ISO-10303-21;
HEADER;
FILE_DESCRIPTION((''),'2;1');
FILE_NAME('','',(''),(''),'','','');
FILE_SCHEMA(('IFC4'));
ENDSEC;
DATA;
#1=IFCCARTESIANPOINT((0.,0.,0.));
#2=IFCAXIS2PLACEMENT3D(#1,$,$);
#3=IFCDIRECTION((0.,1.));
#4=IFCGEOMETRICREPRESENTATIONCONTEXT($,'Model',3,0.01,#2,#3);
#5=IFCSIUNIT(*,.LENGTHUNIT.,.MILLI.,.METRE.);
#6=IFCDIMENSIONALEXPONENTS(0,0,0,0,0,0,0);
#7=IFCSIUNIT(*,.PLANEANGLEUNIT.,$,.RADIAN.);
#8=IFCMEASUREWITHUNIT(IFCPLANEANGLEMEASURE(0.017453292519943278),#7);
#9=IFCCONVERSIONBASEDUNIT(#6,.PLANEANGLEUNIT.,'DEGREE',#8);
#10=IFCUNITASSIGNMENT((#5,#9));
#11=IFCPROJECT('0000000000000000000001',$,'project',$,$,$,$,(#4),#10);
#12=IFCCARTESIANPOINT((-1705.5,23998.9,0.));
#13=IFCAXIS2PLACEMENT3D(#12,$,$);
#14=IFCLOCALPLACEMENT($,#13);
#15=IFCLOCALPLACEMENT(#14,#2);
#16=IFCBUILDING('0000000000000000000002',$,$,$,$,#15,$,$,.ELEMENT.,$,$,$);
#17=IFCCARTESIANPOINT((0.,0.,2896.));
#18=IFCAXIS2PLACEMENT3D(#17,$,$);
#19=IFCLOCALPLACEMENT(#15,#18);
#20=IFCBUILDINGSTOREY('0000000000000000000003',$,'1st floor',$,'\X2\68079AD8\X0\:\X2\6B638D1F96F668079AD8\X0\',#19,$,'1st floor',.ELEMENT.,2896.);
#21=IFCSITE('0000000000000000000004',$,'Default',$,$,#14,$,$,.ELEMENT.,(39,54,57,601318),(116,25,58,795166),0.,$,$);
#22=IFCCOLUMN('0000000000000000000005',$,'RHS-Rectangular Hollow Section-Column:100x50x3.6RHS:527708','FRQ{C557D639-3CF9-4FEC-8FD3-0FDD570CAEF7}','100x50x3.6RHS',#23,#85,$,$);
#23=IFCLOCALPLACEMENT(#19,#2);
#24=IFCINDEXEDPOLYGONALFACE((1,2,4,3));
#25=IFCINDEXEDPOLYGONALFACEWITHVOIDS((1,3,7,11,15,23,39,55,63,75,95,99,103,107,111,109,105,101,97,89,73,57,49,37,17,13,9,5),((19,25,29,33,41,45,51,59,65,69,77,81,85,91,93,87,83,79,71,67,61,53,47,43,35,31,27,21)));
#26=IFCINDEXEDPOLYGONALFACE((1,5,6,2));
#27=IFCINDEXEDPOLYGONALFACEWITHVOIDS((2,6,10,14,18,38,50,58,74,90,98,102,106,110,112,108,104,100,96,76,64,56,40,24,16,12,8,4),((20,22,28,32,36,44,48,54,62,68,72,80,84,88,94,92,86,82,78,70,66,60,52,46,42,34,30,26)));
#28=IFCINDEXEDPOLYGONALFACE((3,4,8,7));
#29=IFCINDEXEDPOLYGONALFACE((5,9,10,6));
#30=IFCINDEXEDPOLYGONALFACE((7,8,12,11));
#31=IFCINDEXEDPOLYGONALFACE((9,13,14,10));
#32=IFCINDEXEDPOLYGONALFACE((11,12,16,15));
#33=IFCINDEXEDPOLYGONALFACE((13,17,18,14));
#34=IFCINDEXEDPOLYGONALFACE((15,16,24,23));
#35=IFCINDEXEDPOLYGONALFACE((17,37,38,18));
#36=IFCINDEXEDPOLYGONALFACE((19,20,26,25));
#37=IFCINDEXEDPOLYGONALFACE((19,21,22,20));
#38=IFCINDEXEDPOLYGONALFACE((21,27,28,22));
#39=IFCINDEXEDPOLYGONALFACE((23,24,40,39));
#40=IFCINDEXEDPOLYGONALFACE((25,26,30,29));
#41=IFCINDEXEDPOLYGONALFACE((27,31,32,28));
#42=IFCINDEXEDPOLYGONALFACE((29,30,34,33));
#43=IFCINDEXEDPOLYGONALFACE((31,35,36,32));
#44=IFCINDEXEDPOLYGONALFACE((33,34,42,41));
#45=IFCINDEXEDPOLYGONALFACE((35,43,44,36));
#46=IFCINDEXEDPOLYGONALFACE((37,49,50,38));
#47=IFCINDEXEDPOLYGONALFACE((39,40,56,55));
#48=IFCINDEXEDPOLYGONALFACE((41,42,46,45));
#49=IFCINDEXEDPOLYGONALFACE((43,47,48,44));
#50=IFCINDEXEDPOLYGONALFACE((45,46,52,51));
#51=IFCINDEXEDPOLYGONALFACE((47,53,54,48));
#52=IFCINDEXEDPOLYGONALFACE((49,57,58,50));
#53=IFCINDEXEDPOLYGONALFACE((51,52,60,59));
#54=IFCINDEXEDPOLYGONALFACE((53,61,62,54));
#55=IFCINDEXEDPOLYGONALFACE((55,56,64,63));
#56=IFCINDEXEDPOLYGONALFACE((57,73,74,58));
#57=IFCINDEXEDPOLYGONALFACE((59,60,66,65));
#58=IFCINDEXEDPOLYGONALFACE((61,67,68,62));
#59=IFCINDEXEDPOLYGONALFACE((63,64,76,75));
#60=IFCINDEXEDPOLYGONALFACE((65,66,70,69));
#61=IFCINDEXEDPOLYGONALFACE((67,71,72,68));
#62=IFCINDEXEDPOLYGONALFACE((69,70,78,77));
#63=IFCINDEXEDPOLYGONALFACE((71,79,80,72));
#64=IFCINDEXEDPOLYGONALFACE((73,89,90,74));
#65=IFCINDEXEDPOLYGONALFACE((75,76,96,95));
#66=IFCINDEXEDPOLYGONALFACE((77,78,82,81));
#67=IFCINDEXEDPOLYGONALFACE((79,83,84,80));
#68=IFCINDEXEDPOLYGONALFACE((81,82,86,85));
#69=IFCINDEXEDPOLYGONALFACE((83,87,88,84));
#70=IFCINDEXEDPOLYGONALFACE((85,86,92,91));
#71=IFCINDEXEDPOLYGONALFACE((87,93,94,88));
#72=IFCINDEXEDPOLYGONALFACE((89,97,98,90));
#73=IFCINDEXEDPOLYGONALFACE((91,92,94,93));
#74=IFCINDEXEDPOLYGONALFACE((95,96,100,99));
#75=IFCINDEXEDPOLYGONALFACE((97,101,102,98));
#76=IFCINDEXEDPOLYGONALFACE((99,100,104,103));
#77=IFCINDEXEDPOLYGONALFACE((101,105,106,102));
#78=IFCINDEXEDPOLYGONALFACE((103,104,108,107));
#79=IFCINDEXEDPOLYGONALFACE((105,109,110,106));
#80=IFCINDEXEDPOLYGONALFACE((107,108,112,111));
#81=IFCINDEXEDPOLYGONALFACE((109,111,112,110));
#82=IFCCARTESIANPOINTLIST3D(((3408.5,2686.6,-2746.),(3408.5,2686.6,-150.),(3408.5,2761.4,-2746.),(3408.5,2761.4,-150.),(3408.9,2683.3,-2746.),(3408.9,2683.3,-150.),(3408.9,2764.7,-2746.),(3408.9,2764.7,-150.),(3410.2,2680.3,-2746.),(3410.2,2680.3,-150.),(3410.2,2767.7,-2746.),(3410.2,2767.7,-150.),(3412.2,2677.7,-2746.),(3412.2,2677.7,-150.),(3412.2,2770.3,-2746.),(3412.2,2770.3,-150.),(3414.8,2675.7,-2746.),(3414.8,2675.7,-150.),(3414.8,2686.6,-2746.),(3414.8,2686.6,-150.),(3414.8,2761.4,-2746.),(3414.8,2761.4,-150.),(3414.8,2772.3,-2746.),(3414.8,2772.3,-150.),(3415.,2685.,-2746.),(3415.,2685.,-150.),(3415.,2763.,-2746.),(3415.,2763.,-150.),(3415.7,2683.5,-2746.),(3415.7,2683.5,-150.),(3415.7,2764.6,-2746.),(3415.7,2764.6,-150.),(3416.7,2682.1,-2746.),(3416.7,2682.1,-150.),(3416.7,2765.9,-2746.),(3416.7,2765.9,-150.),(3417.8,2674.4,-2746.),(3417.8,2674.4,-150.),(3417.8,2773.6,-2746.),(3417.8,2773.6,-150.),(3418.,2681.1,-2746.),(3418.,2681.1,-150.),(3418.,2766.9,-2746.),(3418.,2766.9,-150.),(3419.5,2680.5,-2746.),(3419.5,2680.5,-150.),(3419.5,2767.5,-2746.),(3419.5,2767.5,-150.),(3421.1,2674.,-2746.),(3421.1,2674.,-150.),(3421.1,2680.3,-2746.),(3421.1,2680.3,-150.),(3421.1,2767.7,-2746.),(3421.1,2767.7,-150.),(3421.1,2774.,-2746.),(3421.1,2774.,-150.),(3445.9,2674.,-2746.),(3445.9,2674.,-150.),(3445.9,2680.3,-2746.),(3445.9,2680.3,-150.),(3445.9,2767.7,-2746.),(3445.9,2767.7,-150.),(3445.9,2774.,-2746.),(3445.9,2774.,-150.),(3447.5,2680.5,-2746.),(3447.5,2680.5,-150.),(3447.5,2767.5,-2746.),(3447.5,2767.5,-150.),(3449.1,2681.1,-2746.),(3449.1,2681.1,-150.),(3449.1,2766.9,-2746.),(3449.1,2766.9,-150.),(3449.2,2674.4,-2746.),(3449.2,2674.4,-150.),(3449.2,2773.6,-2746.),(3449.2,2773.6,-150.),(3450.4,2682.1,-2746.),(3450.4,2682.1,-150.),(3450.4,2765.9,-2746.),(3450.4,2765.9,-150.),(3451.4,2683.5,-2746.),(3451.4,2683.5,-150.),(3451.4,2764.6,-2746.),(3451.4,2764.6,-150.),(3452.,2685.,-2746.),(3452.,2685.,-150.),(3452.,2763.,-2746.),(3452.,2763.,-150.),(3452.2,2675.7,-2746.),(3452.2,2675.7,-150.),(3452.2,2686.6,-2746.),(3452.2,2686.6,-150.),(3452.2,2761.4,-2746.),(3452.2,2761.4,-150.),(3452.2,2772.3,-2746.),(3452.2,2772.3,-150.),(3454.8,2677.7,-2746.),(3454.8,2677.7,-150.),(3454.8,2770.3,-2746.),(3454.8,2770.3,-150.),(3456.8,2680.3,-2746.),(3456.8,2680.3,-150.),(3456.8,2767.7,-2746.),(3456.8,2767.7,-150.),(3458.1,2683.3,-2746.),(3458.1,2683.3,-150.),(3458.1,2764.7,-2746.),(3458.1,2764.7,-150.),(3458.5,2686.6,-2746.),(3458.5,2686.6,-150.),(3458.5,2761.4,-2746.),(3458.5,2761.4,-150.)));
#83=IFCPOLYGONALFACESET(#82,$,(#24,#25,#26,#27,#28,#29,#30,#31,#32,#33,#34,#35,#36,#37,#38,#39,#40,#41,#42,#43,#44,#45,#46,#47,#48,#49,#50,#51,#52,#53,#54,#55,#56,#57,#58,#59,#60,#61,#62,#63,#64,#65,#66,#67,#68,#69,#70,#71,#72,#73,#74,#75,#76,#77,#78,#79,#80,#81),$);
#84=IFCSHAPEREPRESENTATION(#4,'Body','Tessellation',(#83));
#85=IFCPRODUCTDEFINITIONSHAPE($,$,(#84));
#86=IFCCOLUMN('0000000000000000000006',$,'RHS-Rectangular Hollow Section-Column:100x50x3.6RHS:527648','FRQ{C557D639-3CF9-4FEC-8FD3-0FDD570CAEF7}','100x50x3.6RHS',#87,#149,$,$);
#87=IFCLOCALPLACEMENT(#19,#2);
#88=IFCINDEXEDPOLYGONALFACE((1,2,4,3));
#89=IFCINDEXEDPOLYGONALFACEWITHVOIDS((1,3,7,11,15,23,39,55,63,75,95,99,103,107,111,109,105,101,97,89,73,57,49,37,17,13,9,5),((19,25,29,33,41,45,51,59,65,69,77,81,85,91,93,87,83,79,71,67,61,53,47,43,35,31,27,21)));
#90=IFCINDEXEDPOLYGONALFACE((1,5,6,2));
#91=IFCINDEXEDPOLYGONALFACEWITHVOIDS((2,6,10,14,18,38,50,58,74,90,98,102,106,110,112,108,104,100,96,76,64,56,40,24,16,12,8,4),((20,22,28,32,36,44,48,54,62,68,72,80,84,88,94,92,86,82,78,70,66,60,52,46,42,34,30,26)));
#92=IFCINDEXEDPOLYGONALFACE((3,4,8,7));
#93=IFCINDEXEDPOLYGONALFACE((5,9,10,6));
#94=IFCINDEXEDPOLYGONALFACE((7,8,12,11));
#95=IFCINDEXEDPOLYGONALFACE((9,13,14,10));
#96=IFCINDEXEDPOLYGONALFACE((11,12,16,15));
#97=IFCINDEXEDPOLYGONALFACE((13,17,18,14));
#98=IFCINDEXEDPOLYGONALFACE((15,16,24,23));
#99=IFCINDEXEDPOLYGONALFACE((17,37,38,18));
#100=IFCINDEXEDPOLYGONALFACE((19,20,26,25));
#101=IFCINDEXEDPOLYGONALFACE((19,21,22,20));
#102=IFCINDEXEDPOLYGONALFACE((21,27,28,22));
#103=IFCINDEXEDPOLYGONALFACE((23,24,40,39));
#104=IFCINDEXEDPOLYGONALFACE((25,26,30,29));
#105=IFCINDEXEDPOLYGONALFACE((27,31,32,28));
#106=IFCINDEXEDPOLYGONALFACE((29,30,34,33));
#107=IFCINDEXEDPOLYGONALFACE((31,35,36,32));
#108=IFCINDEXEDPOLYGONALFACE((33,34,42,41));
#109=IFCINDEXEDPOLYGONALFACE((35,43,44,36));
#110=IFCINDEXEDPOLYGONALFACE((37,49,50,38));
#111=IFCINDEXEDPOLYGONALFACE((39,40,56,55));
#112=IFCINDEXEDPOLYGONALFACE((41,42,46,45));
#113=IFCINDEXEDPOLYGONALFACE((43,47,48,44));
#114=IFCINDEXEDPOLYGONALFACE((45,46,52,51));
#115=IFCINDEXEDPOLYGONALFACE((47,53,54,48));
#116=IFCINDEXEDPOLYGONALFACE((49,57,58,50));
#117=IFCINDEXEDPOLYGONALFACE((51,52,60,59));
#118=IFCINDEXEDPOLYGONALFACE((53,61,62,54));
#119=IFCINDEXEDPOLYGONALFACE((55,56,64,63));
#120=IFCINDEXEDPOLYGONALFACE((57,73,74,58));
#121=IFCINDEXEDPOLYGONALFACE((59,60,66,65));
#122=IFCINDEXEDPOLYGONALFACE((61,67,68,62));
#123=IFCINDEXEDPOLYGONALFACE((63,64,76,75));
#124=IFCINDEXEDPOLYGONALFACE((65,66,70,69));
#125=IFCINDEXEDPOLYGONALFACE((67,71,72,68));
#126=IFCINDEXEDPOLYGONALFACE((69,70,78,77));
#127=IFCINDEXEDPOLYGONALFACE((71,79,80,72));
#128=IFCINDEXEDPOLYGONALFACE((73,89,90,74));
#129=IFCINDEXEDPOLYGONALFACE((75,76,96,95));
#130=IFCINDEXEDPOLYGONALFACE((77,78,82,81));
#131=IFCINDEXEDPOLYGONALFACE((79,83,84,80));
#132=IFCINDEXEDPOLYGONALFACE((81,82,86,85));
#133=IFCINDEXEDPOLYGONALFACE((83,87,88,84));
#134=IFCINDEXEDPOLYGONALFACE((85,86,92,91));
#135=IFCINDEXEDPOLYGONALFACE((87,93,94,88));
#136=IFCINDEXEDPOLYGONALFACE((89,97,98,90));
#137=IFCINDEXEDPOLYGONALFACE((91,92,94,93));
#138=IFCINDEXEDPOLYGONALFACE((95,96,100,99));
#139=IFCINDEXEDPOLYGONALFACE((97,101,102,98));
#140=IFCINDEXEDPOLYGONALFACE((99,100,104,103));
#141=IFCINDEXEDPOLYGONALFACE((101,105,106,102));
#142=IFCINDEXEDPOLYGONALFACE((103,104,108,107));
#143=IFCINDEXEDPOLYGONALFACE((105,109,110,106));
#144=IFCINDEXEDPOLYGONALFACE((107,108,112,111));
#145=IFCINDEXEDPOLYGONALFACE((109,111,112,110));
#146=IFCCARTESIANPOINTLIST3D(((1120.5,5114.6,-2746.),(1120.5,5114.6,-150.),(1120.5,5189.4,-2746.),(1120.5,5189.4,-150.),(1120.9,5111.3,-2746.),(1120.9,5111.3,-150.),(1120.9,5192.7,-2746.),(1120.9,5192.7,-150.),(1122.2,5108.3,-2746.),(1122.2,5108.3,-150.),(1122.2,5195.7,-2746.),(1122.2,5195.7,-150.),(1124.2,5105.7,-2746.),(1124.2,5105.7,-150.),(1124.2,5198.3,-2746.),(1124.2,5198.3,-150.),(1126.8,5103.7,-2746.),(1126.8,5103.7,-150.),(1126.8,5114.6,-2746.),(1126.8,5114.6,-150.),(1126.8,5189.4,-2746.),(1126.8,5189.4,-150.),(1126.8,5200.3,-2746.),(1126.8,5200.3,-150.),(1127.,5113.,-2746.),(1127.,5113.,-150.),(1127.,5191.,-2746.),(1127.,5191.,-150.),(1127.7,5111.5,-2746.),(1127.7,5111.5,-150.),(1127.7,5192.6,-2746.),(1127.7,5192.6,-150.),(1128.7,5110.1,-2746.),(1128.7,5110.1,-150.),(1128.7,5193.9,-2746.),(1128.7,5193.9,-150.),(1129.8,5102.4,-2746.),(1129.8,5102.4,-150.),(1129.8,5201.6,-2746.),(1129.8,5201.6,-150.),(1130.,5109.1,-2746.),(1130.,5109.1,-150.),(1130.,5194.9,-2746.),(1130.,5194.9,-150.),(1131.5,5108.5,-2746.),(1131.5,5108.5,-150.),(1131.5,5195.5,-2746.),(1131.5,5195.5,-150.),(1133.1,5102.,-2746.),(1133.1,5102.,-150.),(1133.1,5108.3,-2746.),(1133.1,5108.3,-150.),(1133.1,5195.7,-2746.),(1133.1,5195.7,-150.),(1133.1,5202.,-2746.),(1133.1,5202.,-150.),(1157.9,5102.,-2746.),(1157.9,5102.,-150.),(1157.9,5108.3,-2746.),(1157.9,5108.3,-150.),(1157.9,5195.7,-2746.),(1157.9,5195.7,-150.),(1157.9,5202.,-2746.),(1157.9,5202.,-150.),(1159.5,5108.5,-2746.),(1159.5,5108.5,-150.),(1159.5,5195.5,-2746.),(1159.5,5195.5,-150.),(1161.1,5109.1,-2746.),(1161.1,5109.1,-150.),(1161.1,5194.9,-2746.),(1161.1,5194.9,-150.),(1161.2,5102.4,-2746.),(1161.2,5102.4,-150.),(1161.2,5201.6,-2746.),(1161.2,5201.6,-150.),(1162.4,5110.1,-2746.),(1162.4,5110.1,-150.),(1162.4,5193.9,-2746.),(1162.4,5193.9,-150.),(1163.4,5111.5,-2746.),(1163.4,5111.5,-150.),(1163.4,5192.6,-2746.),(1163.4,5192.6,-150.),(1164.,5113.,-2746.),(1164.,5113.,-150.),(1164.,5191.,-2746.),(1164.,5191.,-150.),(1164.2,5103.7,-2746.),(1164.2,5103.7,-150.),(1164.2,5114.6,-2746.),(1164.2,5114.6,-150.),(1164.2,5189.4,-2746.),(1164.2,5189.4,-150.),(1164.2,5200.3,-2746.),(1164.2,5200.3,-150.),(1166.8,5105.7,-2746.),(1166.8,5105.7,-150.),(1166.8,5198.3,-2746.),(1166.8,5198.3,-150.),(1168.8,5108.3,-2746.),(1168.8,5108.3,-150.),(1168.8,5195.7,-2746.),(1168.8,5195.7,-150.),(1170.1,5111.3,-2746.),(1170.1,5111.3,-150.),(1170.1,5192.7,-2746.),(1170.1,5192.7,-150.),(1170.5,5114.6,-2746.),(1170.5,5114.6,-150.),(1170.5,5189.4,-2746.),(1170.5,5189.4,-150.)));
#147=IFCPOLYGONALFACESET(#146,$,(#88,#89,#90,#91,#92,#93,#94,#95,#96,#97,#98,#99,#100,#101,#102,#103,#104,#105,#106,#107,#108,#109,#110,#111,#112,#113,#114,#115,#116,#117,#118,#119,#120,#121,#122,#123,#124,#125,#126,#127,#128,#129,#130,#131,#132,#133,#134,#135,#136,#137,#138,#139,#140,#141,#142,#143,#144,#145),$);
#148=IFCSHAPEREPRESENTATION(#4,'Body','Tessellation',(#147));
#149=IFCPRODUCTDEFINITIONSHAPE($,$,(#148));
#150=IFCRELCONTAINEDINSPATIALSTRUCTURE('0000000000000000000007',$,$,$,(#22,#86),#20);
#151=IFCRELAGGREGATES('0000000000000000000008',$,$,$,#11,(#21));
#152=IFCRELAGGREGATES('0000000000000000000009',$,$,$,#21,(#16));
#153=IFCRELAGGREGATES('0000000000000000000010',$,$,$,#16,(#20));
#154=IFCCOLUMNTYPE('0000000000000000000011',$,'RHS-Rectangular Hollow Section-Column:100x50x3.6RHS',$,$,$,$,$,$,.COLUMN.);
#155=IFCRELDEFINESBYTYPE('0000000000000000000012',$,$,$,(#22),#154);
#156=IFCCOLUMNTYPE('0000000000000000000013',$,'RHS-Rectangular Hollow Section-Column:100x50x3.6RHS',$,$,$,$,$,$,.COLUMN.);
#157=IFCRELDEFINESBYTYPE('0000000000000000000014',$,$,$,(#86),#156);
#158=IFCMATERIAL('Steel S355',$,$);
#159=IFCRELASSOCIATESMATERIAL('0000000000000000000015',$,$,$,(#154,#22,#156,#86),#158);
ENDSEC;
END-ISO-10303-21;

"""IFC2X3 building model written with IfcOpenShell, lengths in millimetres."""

from ifc_helpers import new_model, entity, si_unit, converted_unit, point, direction, frame, frame_2d, origin, origin_2d, place, context, project, spatial, circle_curve, line_curve, trimmed, segment, composite_curve, hollow_rectangle, outline, extrude, clip, halfspace, material, type_object, element, save


model = new_model("IFC2X3")

# Units and contexts
model_context = context("Model", 3, precision=0.01, world=origin(), true_north=direction((0.0, 1.0)))
ifc_project = project(units=[si_unit("LENGTHUNIT", "METRE", prefix="MILLI"), converted_unit("PLANEANGLEUNIT", "DEGREE", entity("IfcPlaneAngleMeasure", 0.017453292519943278), si_unit("PLANEANGLEUNIT", "RADIAN"), dimensions=[0, 0, 0, 0, 0, 0, 0])], contexts=[model_context])

# Site, building, storey
site_placement = place(None, frame((-1705.5, 23998.9, 0.0)))
site = spatial("IfcSite", under=ifc_project, at=site_placement, Name="Default", CompositionType="ELEMENT", RefLatitude=(39, 54, 57, 601318), RefLongitude=(116, 25, 58, 795166), RefElevation=0.0)
building_placement = place(site_placement, origin())
building = spatial("IfcBuilding", under=site, at=building_placement, CompositionType="ELEMENT")
storey_placement = place(building_placement, frame((0.0, 0.0, 2896.0)))
storey = spatial("IfcBuildingStorey", under=building, at=storey_placement, Name="1st floor", ObjectType="标高:正负零标高", LongName="1st floor", CompositionType="ELEMENT", Elevation=2896.0)

# Column
ifc_material_1 = material(Name="Steel S355")
column_type_1 = type_object("IfcColumnType", Name="RHS-Rectangular Hollow Section-Column:100x50x3.6RHS", PredefinedType="COLUMN", material=ifc_material_1)
column_1_placement = place(storey_placement, frame((3433.5, 2724.0, -150.0), z_axis=(0.0, 0.0, 1.0), x_axis=(-1.0, 0.0, 0.0)))
element("IfcColumn", 1, at=column_1_placement, inside=storey, type_object=column_type_1, material=ifc_material_1, Name="RHS-Rectangular Hollow Section-Column:100x50x3.6RHS:527708", Description="FRQ{C557D639-3CF9-4FEC-8FD3-0FDD570CAEF7}", ObjectType="100x50x3.6RHS", context=model_context, shape_type="Clipping", body=[
    clip(extrude(hollow_rectangle(XDim=50.0, YDim=100.0, WallThickness=6.3, InnerFilletRadius=6.3, OuterFilletRadius=12.6, at=origin_2d()), origin(), (0.0, 0.0, -1.0), 2651.9), halfspace(frame((3433.5, 2724.0, -2596.0), z_axis=(0.0, 0.0, 1.0), x_axis=(-1.0, 0.0, 0.0)), True)),
])

# Column, opening
column_type_2 = type_object("IfcColumnType", Name="RHS-Rectangular Hollow Section-Column:100x50x3.6RHS", PredefinedType="COLUMN", material=ifc_material_1)
column_2_placement = place(storey_placement, frame((1145.5, 5152.0, -19.1)))
column_2 = element("IfcColumn", 2, at=column_2_placement, inside=storey, type_object=column_type_2, material=ifc_material_1, Name="RHS-Rectangular Hollow Section-Column:100x50x3.6RHS:527648", Description="FRQ{C557D639-3CF9-4FEC-8FD3-0FDD570CAEF7}", ObjectType="100x50x3.6RHS", context=model_context, shape_type="Clipping", body=[
    clip(clip(extrude(hollow_rectangle(XDim=50.0, YDim=100.0, WallThickness=6.3, InnerFilletRadius=6.3, OuterFilletRadius=12.6, at=origin_2d()), origin(), (0.0, 0.0, -1.0), 2782.8), halfspace(frame((-1145.5, -5152.0, -55.9), z_axis=(0.0, 0.0, -1.0), x_axis=(-1.0, 0.0, 0.0)), True)), halfspace(frame((-1145.5, -5152.0, -2726.9), z_axis=(0.0, 0.0, 1.0), x_axis=(1.0, 0.0, 0.0)), True)),
])
opening_1_placement = place(column_2_placement, frame((0.0, -150.1, -130.9), z_axis=(0.0, 1.0, 0.0), x_axis=(-1.0, 0.0, 0.0)))
element("IfcOpeningElement", 3, at=opening_1_placement, cuts=column_2, ObjectType="Opening", context=model_context, shape_type="SweptSolid", body=[
    extrude(outline(composite_curve([segment(trimmed(circle_curve(frame_2d((43.0, 32.0), x_axis=(1.0, 0.0)), 32.0), [point((43.0, 0.0))], [point((75.0, 32.0))], True, "CARTESIAN"), True, "CONTINUOUS"), segment(trimmed(line_curve((75.0, 32.0), (0.0, 1.0), 86.0), [point((75.0, 32.0))], [point((75.0, 118.0))], True, "CARTESIAN"), True, "CONTINUOUS"), segment(trimmed(circle_curve(frame_2d((43.0, 118.0), x_axis=(1.0, 0.0)), 32.0), [point((75.0, 118.0))], [point((43.0, 150.0))], True, "CARTESIAN"), True, "CONTINUOUS"), segment(trimmed(line_curve((43.0, 150.0), (-1.0, 0.0), 86.0), [point((43.0, 150.0))], [point((-43.0, 150.0))], True, "CARTESIAN"), True, "CONTINUOUS"), segment(trimmed(circle_curve(frame_2d((-43.0, 118.0), x_axis=(1.0, 0.0)), 32.0), [point((-43.0, 150.0))], [point((-75.0, 118.0))], True, "CARTESIAN"), True, "CONTINUOUS"), segment(trimmed(line_curve((-75.0, 118.0), (0.0, -1.0), 86.0), [point((-75.0, 118.0))], [point((-75.0, 32.0))], True, "CARTESIAN"), True, "CONTINUOUS"), segment(trimmed(circle_curve(frame_2d((-43.0, 32.0), x_axis=(1.0, 0.0)), 32.0), [point((-75.0, 32.0))], [point((-43.0, 0.0))], True, "CARTESIAN"), True, "CONTINUOUS"), segment(trimmed(line_curve((-43.0, 0.0), (1.0, 0.0), 86.0), [point((-43.0, 0.0))], [point((43.0, 0.0))], True, "CARTESIAN"), True, "CONTINUOUS")], self_intersect="UNKNOWN")), origin(), (0.0, 0.0, 1.0), 300.2),
])

save(model, "model.ifc")
